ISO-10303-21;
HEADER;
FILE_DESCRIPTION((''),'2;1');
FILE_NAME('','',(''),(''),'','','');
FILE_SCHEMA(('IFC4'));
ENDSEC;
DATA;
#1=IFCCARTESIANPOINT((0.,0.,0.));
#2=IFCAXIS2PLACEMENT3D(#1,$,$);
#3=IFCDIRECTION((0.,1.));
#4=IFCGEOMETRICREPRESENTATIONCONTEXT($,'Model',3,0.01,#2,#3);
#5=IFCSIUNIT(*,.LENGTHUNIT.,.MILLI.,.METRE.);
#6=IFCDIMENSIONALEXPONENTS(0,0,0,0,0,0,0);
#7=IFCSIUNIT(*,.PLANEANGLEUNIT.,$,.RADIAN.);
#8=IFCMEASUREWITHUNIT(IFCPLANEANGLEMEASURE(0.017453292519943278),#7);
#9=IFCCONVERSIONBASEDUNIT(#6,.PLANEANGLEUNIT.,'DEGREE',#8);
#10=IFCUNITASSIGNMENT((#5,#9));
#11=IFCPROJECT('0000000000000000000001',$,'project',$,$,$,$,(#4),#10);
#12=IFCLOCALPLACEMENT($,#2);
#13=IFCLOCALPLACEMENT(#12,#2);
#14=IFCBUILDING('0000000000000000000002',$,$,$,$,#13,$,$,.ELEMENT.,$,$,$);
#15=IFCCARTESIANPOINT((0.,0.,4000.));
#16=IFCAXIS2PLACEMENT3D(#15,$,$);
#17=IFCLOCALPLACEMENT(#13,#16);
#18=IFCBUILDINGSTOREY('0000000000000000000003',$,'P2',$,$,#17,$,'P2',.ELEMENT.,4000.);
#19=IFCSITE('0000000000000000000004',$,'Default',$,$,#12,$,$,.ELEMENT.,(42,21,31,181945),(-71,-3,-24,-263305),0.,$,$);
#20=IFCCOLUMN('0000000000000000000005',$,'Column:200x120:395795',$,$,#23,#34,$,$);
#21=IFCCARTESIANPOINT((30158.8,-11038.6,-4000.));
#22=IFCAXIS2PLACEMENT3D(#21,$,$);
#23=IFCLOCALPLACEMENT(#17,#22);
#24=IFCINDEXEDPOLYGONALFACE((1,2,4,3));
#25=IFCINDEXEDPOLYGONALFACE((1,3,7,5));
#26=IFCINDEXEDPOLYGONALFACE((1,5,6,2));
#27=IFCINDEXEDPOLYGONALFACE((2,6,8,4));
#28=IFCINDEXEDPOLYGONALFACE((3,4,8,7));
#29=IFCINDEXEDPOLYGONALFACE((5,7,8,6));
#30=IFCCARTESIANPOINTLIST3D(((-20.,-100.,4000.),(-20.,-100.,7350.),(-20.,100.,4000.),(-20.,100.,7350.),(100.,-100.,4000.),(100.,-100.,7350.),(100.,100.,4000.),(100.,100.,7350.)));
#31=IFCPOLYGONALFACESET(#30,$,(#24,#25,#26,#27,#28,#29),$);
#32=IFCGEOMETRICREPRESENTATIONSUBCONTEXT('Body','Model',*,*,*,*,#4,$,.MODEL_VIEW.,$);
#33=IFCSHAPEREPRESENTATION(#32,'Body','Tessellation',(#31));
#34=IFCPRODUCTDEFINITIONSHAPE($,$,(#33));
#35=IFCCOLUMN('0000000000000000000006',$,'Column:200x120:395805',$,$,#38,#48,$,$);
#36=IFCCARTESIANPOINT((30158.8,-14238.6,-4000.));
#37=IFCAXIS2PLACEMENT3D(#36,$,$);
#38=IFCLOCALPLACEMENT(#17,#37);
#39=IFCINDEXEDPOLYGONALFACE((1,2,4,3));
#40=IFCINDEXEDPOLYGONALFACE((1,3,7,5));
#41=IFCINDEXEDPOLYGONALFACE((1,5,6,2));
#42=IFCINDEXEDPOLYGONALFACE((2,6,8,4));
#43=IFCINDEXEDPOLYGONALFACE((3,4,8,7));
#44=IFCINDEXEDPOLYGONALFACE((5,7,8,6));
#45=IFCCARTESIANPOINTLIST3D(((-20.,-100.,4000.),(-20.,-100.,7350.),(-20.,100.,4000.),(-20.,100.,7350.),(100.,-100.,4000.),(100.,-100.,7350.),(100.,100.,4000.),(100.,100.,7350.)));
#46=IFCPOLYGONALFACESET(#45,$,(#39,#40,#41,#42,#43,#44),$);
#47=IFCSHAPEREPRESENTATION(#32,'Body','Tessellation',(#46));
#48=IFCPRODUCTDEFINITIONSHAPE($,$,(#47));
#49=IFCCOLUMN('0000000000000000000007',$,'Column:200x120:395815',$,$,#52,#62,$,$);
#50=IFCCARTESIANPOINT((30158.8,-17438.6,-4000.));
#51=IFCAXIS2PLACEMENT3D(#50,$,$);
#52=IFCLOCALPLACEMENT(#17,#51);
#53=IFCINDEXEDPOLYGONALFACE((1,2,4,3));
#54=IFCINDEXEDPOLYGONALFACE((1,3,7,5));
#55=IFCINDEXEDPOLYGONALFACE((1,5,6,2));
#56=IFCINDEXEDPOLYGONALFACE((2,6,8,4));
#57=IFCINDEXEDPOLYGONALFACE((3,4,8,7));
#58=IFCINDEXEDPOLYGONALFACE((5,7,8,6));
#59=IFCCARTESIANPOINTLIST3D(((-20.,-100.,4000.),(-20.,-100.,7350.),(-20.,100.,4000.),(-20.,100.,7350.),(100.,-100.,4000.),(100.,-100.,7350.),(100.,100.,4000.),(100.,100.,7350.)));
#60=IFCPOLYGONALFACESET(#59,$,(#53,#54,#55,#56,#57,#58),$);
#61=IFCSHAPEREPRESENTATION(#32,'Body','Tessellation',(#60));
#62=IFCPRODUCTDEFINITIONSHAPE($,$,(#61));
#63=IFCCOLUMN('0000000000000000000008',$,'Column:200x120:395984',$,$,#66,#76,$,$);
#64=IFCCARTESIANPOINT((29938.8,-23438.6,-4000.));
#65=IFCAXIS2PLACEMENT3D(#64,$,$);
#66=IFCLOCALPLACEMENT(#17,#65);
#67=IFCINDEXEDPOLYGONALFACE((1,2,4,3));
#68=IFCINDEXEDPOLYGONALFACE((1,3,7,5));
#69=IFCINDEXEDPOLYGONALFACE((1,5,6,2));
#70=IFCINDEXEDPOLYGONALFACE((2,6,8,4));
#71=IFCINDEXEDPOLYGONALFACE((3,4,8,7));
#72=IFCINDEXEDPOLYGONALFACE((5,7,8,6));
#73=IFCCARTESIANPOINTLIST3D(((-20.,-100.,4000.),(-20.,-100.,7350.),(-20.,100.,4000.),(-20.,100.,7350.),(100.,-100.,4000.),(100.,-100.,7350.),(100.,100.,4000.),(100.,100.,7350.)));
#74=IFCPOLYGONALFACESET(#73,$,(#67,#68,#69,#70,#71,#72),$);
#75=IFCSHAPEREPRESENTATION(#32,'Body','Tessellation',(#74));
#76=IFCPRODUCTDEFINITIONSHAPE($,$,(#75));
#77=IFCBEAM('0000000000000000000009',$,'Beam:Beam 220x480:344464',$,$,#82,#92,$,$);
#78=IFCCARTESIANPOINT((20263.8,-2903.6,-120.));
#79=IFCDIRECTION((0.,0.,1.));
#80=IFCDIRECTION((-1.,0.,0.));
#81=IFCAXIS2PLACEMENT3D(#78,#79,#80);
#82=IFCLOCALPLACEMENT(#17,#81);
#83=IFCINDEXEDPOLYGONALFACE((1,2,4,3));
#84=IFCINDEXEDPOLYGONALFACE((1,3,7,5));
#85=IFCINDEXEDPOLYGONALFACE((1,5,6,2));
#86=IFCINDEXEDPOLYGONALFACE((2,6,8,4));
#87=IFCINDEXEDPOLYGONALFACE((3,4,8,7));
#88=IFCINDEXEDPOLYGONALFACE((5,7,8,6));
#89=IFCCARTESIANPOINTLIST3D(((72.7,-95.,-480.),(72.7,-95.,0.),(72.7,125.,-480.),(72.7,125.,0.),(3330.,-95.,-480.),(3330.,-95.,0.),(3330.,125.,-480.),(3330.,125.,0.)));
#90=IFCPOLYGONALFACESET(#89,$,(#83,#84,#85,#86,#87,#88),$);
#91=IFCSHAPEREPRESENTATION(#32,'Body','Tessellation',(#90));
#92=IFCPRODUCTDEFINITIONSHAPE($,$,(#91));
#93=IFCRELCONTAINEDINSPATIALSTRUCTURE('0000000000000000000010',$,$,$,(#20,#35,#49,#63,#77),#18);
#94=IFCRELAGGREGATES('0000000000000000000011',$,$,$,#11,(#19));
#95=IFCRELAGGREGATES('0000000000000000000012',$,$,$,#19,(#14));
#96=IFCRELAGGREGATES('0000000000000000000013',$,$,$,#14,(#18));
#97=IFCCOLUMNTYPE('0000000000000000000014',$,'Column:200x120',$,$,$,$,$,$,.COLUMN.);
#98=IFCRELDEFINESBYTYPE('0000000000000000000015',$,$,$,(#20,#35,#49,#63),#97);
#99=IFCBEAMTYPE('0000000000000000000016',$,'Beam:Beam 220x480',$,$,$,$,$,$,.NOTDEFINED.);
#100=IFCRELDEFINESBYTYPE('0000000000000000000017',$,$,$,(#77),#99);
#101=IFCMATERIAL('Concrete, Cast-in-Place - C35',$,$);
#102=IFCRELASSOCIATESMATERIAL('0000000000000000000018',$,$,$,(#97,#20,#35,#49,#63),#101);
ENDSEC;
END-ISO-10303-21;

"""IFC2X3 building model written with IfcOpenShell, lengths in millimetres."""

from ifc_helpers import new_model, entity, si_unit, converted_unit, direction, frame, frame_2d, origin, origin_2d_with_axis, place, context, subcontext, project, spatial, rectangle, extrude, source, transform, mapped, material, type_object, type_shapes, element, save


model = new_model("IFC2X3")

# Units and contexts
model_context = context("Model", 3, precision=0.01, world=origin(), true_north=direction((0.0, 1.0)))
body_context = subcontext(model_context, "Body", "Model", "MODEL_VIEW")
ifc_project = project(units=[si_unit("LENGTHUNIT", "METRE", prefix="MILLI"), converted_unit("PLANEANGLEUNIT", "DEGREE", entity("IfcPlaneAngleMeasure", 0.017453292519943278), si_unit("PLANEANGLEUNIT", "RADIAN"), dimensions=[0, 0, 0, 0, 0, 0, 0])], contexts=[model_context])

# Site, building, storey
site_placement = place(None, origin())
site = spatial("IfcSite", under=ifc_project, at=site_placement, Name="Default", CompositionType="ELEMENT", RefLatitude=(42, 21, 31, 181945), RefLongitude=(-71, -3, -24, -263305), RefElevation=0.0)
building_placement = place(site_placement, origin())
building = spatial("IfcBuilding", under=site, at=building_placement, CompositionType="ELEMENT")
storey_placement = place(building_placement, frame((0.0, 0.0, 4000.0)))
storey = spatial("IfcBuildingStorey", under=building, at=storey_placement, Name="P2", LongName="P2", CompositionType="ELEMENT", Elevation=4000.0)

# Columns
ifc_material = material(Name="Concrete, Cast-in-Place - C35")
column_type_1 = type_object("IfcColumnType", Name="Column:200x120", PredefinedType="COLUMN", material=ifc_material)
shared_shape_1 = source(origin(), body_context, "Body", "SweptSolid", [
    extrude(rectangle(XDim=120.0, YDim=200.0, at=origin_2d_with_axis()), frame((40.0, 0.0, 4000.0), z_axis=(0.0, 0.0, 1.0), x_axis=(-1.0, 0.0, 0.0)), (0.0, 0.0, 1.0), 3350.0),
])
type_shapes(column_type_1, [shared_shape_1])
for number, where, name in (
    (1, (30158.8, -11038.6, -4000.0), "Column:200x120:395795"),
    (2, (30158.8, -14238.6, -4000.0), "Column:200x120:395805"),
    (3, (30158.8, -17438.6, -4000.0), "Column:200x120:395815"),
    (4, (29938.8, -23438.6, -4000.0), "Column:200x120:395984"),
):
    element("IfcColumn", number, at=place(storey_placement, frame(where)), inside=storey, type_object=column_type_1, material=ifc_material, Name=name, context=body_context, shape_type="MappedRepresentation", body=[
        mapped(shared_shape_1, transform((0.0, 0.0, 0.0), scale=1.0)),
    ])

# Beam
beam_type_1 = type_object("IfcBeamType", Name="Beam:Beam 220x480", PredefinedType="NOTDEFINED")
beam_1_placement = place(storey_placement, frame((20263.8, -2903.6, -120.0), z_axis=(0.0, 0.0, 1.0), x_axis=(-1.0, 0.0, 0.0)))
element("IfcBeam", 5, at=beam_1_placement, inside=storey, type_object=beam_type_1, Name="Beam:Beam 220x480:344464", context=body_context, shape_type="SweptSolid", body=[
    extrude(rectangle(XDim=480.0, YDim=220.0, at=frame_2d((0.0, 0.0), x_axis=(1.0, 0.0))), frame((72.7, 15.0, -240.0), z_axis=(1.0, 0.0, 0.0), x_axis=(0.0, 0.0, -1.0)), (0.0, 0.0, 1.0), 3257.3),
])

save(model, "model.ifc")
